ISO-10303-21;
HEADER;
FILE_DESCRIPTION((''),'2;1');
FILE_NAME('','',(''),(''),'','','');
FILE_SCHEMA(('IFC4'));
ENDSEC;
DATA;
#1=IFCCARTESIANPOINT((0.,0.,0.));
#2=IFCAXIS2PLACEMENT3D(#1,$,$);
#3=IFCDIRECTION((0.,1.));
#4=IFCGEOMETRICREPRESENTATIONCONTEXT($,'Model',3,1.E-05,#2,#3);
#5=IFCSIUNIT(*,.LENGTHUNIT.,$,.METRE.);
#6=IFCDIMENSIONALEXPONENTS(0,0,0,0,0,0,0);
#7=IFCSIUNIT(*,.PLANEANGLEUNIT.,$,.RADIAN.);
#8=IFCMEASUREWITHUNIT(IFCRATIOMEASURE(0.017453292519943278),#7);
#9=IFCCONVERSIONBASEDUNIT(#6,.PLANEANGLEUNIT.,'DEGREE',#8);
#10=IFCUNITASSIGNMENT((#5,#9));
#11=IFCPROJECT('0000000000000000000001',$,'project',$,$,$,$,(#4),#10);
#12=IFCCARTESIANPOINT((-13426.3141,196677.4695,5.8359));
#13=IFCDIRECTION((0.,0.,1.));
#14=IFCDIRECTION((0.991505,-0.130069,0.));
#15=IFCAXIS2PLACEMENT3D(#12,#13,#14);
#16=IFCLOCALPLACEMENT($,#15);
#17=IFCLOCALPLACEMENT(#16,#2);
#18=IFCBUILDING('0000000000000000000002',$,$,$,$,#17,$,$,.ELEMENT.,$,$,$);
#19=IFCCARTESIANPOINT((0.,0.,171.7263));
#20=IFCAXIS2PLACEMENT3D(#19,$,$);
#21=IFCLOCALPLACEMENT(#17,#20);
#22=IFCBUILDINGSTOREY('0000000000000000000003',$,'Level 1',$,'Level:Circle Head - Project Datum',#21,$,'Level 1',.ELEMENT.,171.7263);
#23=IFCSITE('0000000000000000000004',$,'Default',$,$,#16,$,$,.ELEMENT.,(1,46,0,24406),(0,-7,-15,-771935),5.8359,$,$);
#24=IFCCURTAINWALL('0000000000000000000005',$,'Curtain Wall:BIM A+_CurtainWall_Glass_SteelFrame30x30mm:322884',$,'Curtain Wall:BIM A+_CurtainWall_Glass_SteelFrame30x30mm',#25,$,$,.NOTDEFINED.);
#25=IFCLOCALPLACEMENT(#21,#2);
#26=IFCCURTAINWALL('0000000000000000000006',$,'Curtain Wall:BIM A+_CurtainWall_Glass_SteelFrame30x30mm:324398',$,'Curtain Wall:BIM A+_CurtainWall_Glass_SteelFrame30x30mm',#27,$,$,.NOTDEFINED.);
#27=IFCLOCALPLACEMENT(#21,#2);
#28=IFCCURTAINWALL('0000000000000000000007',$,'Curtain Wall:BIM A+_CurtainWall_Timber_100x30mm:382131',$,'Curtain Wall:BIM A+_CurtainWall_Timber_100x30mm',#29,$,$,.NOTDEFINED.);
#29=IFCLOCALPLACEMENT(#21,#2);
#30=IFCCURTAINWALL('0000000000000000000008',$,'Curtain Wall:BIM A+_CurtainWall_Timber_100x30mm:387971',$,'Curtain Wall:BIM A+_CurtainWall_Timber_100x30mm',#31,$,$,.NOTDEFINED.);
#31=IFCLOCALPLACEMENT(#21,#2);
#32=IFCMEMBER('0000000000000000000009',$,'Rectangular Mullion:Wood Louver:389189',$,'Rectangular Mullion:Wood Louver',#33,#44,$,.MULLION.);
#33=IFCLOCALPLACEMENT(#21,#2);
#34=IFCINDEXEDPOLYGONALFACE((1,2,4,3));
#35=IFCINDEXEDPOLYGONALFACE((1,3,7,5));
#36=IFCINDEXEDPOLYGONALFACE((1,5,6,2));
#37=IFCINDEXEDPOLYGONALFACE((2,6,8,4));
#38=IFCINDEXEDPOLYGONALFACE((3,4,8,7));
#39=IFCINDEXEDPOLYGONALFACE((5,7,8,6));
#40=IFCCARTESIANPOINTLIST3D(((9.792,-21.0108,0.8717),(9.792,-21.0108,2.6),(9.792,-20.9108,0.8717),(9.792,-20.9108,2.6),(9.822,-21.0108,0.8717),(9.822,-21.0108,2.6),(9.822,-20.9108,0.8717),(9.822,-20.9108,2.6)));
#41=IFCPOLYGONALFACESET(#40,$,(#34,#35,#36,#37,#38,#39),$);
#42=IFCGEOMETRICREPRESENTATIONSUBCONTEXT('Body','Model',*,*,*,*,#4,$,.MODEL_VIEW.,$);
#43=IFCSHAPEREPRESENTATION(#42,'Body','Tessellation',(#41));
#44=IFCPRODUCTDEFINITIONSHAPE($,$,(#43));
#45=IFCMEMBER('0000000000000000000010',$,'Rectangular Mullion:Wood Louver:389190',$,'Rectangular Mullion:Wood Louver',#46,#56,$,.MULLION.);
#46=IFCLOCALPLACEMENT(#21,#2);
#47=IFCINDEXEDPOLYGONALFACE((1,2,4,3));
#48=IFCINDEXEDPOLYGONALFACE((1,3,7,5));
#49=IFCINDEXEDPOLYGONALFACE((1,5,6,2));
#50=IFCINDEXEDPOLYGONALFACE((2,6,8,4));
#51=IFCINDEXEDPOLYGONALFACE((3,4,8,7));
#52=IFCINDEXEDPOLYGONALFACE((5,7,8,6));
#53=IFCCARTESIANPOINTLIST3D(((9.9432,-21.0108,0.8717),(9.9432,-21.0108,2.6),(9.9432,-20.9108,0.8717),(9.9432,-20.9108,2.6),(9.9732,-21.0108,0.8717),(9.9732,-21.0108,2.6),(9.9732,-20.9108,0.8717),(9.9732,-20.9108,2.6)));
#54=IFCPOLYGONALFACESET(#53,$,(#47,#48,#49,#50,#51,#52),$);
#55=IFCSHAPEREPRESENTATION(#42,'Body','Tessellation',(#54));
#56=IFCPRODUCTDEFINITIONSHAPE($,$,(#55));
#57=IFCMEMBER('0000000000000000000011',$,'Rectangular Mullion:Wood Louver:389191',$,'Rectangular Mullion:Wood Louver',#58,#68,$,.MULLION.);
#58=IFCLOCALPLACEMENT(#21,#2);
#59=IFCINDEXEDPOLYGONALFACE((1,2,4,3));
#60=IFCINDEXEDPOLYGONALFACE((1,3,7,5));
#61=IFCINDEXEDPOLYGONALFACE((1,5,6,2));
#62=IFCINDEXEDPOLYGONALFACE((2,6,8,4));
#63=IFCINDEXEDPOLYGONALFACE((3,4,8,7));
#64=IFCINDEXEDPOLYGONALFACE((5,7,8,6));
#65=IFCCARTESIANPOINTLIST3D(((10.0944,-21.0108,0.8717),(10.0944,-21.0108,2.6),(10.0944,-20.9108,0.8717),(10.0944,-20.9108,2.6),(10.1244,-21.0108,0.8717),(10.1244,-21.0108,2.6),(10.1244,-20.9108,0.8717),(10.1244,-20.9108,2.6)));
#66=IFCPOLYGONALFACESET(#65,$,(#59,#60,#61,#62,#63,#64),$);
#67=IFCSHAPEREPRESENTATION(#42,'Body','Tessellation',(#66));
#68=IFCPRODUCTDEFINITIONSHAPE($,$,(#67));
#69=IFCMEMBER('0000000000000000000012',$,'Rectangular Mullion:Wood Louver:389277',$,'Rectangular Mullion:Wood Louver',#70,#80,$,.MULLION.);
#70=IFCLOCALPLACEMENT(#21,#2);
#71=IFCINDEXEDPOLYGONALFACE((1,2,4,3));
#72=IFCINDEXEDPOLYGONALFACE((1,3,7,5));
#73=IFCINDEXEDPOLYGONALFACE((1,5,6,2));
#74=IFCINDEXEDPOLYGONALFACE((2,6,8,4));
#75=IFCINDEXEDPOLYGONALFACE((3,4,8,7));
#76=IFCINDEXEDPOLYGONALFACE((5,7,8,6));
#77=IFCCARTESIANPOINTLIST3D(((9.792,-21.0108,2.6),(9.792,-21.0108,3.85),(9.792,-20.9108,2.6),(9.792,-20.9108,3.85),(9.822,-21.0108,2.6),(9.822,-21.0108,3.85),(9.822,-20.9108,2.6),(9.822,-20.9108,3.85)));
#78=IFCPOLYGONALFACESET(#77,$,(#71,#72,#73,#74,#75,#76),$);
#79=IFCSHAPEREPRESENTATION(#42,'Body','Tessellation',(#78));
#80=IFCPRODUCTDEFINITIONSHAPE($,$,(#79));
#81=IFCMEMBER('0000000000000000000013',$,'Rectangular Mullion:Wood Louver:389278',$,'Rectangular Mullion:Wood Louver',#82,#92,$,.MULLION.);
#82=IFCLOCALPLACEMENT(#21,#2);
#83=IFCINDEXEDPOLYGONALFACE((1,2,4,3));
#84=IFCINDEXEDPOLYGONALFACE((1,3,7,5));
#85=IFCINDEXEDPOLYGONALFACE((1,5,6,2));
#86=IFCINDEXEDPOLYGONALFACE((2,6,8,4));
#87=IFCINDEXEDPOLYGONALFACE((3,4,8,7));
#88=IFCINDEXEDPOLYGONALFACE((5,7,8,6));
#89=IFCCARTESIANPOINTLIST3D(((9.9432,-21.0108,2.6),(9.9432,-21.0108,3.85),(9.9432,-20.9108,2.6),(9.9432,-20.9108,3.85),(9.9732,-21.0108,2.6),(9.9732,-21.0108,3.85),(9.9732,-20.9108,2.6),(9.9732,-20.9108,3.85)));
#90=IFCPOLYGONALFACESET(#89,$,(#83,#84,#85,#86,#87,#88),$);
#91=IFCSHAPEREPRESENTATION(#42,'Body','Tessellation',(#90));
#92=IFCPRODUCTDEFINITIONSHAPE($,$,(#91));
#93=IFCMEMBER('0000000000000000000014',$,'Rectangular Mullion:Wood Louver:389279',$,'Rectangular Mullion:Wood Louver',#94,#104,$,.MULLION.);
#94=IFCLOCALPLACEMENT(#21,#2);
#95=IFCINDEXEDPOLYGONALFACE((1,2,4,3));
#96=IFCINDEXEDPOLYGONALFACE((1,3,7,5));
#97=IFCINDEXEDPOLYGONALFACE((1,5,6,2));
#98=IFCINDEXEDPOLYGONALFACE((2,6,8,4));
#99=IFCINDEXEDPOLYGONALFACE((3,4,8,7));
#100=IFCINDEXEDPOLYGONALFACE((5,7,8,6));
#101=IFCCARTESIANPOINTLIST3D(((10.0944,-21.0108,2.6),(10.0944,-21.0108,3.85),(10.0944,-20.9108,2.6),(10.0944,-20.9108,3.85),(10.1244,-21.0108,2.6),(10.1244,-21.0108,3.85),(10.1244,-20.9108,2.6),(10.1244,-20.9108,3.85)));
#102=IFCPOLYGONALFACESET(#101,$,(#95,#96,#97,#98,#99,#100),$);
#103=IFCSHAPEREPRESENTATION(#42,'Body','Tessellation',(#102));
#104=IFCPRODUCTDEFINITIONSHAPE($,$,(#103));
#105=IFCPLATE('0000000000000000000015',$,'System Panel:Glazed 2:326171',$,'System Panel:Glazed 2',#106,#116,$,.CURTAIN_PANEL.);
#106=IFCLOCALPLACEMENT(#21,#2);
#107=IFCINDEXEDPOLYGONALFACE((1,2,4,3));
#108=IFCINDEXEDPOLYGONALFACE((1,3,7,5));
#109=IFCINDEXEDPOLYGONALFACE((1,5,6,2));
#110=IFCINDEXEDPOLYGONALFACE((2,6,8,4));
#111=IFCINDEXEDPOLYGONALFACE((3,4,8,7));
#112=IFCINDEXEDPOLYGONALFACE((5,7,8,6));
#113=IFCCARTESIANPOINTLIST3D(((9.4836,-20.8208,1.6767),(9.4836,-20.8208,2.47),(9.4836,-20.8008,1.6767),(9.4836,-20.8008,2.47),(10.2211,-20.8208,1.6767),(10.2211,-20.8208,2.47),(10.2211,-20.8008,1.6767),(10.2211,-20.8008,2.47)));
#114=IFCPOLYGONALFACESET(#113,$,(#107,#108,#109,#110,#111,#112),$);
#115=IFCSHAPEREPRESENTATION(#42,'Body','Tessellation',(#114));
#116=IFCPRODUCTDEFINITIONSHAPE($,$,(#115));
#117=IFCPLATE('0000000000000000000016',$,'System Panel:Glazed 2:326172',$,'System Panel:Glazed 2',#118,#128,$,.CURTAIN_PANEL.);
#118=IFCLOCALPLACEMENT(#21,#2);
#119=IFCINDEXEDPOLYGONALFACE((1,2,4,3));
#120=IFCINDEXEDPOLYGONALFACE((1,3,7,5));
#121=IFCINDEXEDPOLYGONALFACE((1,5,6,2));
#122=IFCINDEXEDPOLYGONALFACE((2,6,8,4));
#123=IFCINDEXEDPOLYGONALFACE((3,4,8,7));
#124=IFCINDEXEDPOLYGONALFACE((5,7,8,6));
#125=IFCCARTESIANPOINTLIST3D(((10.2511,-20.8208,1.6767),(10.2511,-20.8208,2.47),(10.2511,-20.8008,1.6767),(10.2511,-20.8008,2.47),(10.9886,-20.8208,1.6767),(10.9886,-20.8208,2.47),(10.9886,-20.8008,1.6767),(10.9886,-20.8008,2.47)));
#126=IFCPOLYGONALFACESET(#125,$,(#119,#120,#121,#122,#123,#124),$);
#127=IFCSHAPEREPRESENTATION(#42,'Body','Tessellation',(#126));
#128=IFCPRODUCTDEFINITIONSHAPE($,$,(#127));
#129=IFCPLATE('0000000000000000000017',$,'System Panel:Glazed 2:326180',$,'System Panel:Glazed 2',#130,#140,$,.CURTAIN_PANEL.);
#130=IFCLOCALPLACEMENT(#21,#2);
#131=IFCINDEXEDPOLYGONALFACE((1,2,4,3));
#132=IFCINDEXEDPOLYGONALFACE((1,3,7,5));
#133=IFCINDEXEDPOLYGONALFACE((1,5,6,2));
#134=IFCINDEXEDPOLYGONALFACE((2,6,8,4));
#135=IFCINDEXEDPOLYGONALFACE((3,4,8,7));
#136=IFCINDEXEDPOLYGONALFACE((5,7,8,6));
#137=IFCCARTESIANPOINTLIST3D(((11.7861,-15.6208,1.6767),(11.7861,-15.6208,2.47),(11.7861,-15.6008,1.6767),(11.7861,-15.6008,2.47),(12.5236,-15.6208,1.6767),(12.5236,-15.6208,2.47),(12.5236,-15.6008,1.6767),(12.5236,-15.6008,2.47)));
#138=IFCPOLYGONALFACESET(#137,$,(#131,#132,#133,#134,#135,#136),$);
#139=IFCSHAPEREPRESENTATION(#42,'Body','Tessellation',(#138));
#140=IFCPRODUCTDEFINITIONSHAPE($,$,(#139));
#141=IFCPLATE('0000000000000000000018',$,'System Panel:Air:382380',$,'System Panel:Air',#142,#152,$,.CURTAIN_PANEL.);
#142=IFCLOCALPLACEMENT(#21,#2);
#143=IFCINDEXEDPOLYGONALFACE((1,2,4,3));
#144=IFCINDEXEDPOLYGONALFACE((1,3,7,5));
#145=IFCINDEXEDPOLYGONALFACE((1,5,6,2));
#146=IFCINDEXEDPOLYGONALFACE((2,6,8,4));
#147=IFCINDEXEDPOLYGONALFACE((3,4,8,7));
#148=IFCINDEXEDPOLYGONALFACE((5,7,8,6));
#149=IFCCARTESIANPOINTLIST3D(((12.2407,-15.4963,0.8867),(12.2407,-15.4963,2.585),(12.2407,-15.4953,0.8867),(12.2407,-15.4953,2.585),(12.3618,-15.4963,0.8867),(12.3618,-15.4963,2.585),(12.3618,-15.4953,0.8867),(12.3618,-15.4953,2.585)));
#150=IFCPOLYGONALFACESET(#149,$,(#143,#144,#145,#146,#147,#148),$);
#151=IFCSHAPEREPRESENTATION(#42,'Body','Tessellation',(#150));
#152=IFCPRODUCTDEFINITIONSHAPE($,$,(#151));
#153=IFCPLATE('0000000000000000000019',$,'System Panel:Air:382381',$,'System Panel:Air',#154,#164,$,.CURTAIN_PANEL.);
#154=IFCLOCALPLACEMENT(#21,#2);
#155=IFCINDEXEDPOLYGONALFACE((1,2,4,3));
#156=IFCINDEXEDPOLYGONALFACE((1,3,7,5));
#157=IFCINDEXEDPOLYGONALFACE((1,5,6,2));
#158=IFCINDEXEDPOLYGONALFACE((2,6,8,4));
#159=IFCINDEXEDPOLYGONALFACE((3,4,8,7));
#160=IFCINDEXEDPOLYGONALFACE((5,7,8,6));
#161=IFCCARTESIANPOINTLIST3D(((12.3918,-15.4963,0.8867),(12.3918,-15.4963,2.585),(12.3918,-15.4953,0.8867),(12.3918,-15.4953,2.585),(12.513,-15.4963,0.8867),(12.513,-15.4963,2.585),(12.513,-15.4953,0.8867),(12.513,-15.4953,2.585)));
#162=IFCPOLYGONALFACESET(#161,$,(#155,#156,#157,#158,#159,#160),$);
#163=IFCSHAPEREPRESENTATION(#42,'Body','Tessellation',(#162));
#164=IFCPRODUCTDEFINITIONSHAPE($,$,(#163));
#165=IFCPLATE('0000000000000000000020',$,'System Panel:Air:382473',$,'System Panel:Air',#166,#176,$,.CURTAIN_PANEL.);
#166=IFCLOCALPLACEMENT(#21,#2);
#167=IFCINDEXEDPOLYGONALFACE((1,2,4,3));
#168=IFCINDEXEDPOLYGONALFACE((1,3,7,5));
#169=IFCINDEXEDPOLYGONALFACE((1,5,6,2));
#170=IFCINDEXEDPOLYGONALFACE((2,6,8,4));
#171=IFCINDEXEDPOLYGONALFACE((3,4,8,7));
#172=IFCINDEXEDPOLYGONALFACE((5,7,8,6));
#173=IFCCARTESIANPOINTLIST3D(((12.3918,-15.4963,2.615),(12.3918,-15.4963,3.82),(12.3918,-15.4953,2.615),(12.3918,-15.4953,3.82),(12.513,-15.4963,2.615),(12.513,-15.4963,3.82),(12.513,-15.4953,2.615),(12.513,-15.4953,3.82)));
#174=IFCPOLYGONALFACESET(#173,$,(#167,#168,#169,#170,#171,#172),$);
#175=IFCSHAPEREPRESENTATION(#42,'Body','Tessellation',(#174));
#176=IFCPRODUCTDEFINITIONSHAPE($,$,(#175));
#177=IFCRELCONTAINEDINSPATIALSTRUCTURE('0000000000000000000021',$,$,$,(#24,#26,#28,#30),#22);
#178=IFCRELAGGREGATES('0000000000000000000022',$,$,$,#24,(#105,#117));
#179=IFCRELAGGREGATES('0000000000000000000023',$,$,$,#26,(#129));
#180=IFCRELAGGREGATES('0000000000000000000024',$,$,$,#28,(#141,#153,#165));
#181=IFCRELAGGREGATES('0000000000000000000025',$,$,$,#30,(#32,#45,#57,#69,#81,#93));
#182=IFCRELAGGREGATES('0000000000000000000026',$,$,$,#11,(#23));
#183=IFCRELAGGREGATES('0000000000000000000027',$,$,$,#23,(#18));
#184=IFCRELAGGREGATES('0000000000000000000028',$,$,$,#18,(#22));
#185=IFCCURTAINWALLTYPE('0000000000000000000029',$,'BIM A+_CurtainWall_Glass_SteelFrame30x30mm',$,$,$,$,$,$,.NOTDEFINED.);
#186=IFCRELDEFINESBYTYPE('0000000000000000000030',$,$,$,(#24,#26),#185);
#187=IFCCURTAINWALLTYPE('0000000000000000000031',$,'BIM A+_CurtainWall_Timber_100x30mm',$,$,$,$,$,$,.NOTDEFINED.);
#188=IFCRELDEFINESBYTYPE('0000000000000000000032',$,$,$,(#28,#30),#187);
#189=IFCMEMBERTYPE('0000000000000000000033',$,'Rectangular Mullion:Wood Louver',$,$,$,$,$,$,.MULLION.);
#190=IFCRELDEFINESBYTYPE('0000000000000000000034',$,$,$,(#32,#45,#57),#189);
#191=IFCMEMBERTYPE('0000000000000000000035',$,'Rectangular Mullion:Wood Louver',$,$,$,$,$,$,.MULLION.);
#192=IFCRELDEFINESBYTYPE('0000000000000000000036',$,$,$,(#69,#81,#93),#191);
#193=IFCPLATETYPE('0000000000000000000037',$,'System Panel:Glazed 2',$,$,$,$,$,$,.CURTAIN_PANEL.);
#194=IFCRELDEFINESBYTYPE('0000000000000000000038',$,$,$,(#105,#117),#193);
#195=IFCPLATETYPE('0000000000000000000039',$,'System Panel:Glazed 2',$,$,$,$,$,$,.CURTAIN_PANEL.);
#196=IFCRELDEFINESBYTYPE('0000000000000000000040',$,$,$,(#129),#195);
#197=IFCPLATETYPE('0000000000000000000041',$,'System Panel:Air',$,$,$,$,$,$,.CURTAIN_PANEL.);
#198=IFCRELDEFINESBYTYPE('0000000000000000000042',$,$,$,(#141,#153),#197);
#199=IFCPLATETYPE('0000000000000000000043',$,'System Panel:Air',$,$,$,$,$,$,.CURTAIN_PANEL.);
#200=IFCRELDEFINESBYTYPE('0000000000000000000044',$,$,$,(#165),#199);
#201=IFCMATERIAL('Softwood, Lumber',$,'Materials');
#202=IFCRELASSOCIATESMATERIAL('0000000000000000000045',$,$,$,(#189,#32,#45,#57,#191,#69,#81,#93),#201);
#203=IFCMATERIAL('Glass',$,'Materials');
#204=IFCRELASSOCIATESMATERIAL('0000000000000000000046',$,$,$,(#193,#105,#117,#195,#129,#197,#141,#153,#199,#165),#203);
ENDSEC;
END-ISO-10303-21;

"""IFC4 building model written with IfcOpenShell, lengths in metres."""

from ifc_helpers import new_model, entity, si_unit, converted_unit, direction, frame, origin, place, context, subcontext, project, spatial, indexed_curve, outline, extrude, source, transform, mapped, material, type_object, type_shapes, element, aggregate, save


model = new_model("IFC4")

# Units and contexts
model_context = context("Model", 3, precision=1e-05, world=origin(), true_north=direction((0.0, 1.0)))
body_context = subcontext(model_context, "Body", "Model", "MODEL_VIEW")
ifc_project = project(units=[si_unit("LENGTHUNIT", "METRE"), converted_unit("PLANEANGLEUNIT", "DEGREE", entity("IfcRatioMeasure", 0.017453292519943278), si_unit("PLANEANGLEUNIT", "RADIAN"), dimensions=[0, 0, 0, 0, 0, 0, 0])], contexts=[model_context])

# Site, building, storey
site_placement = place(None, frame((-13426.3141, 196677.4695, 5.8359), z_axis=(0.0, 0.0, 1.0), x_axis=(0.991505, -0.130069, 0.0)))
site = spatial("IfcSite", under=ifc_project, at=site_placement, Name="Default", CompositionType="ELEMENT", RefLatitude=(1, 46, 0, 24406), RefLongitude=(0, -7, -15, -771935), RefElevation=5.8359)
building_placement = place(site_placement, origin())
building = spatial("IfcBuilding", under=site, at=building_placement, CompositionType="ELEMENT")
storey_placement = place(building_placement, frame((0.0, 0.0, 171.7263)))
storey = spatial("IfcBuildingStorey", under=building, at=storey_placement, Name="Level 1", ObjectType="Level:Circle Head - Project Datum", LongName="Level 1", CompositionType="ELEMENT", Elevation=171.7263)

# Curtain walls, members
curtain_wall_type_1 = type_object("IfcCurtainWallType", Name="BIM A+_CurtainWall_Glass_SteelFrame30x30mm", PredefinedType="NOTDEFINED")
curtain_wall_1_placement = place(storey_placement, frame((0.0, 0.0, -171.7263)))
curtain_wall_1 = element("IfcCurtainWall", 1, at=curtain_wall_1_placement, inside=storey, type_object=curtain_wall_type_1, Name="Curtain Wall:BIM A+_CurtainWall_Glass_SteelFrame30x30mm:322884", ObjectType="Curtain Wall:BIM A+_CurtainWall_Glass_SteelFrame30x30mm", PredefinedType="NOTDEFINED")
curtain_wall_2_placement = place(storey_placement, frame((0.0, 0.0, -171.7263)))
curtain_wall_2 = element("IfcCurtainWall", 2, at=curtain_wall_2_placement, inside=storey, type_object=curtain_wall_type_1, Name="Curtain Wall:BIM A+_CurtainWall_Glass_SteelFrame30x30mm:324398", ObjectType="Curtain Wall:BIM A+_CurtainWall_Glass_SteelFrame30x30mm", PredefinedType="NOTDEFINED")
curtain_wall_type_2 = type_object("IfcCurtainWallType", Name="BIM A+_CurtainWall_Timber_100x30mm", PredefinedType="NOTDEFINED")
curtain_wall_3_placement = place(storey_placement, frame((0.0, 0.0, -171.7263)))
curtain_wall_3 = element("IfcCurtainWall", 3, at=curtain_wall_3_placement, inside=storey, type_object=curtain_wall_type_2, Name="Curtain Wall:BIM A+_CurtainWall_Timber_100x30mm:382131", ObjectType="Curtain Wall:BIM A+_CurtainWall_Timber_100x30mm", PredefinedType="NOTDEFINED")
ifc_material_1 = material(Name="Softwood, Lumber", Category="Materials")
curtain_wall_4_placement = place(storey_placement, frame((0.0, 0.0, -171.7263)))
curtain_wall_4 = element("IfcCurtainWall", 4, at=curtain_wall_4_placement, inside=storey, type_object=curtain_wall_type_2, Name="Curtain Wall:BIM A+_CurtainWall_Timber_100x30mm:387971", ObjectType="Curtain Wall:BIM A+_CurtainWall_Timber_100x30mm", PredefinedType="NOTDEFINED")
member_type_1 = type_object("IfcMemberType", Name="Rectangular Mullion:Wood Louver", PredefinedType="MULLION", material=ifc_material_1)
shared_shape_1 = source(origin(), body_context, "Body", "SweptSolid", [
    extrude(outline(indexed_curve([(-0.05, -0.015), (0.05, -0.015), (0.05, 0.015), (-0.05, 0.015), (-0.05, -0.015)], self_intersect=False)), frame((0.0, 0.035, -1.7283), z_axis=(0.0, 0.0, 1.0), x_axis=(0.0, -1.0, 0.0)), (0.0, 0.0, 1.0), 1.7283),
])
type_shapes(member_type_1, [shared_shape_1])
member_1_placement = place(curtain_wall_4_placement, frame((9.807, -20.9258, 172.598), z_axis=(0.0, 0.0, -1.0), x_axis=(1.0, 0.0, 0.0)))
member_1 = element("IfcMember", 5, at=member_1_placement, type_object=member_type_1, material=ifc_material_1, Name="Rectangular Mullion:Wood Louver:389189", ObjectType="Rectangular Mullion:Wood Louver", PredefinedType="MULLION", context=body_context, shape_type="MappedRepresentation", body=[
    mapped(shared_shape_1, transform((0.0, 0.0, 0.0), scale=1.0)),
])
member_2_placement = place(curtain_wall_4_placement, frame((9.9582, -20.9258, 172.598), z_axis=(0.0, 0.0, -1.0), x_axis=(1.0, 0.0, 0.0)))
member_2 = element("IfcMember", 6, at=member_2_placement, type_object=member_type_1, material=ifc_material_1, Name="Rectangular Mullion:Wood Louver:389190", ObjectType="Rectangular Mullion:Wood Louver", PredefinedType="MULLION", context=body_context, shape_type="MappedRepresentation", body=[
    mapped(shared_shape_1, transform((0.0, 0.0, 0.0), scale=1.0)),
])
member_3_placement = place(curtain_wall_4_placement, frame((10.1094, -20.9258, 172.598), z_axis=(0.0, 0.0, -1.0), x_axis=(1.0, 0.0, 0.0)))
member_3 = element("IfcMember", 7, at=member_3_placement, type_object=member_type_1, material=ifc_material_1, Name="Rectangular Mullion:Wood Louver:389191", ObjectType="Rectangular Mullion:Wood Louver", PredefinedType="MULLION", context=body_context, shape_type="MappedRepresentation", body=[
    mapped(shared_shape_1, transform((0.0, 0.0, 0.0), scale=1.0)),
])
member_type_2 = type_object("IfcMemberType", Name="Rectangular Mullion:Wood Louver", PredefinedType="MULLION", material=ifc_material_1)
shared_shape_2 = source(origin(), body_context, "Body", "SweptSolid", [
    extrude(outline(indexed_curve([(-0.05, -0.015), (0.05, -0.015), (0.05, 0.015), (-0.05, 0.015), (-0.05, -0.015)], self_intersect=False)), frame((0.0, 0.035, -1.25), z_axis=(0.0, 0.0, 1.0), x_axis=(0.0, -1.0, 0.0)), (0.0, 0.0, 1.0), 1.25),
])
type_shapes(member_type_2, [shared_shape_2])
member_4_placement = place(curtain_wall_4_placement, frame((9.807, -20.9258, 174.3263), z_axis=(0.0, 0.0, -1.0), x_axis=(1.0, 0.0, 0.0)))
member_4 = element("IfcMember", 8, at=member_4_placement, type_object=member_type_2, material=ifc_material_1, Name="Rectangular Mullion:Wood Louver:389277", ObjectType="Rectangular Mullion:Wood Louver", PredefinedType="MULLION", context=body_context, shape_type="MappedRepresentation", body=[
    mapped(shared_shape_2, transform((0.0, 0.0, 0.0), scale=1.0)),
])
member_5_placement = place(curtain_wall_4_placement, frame((9.9582, -20.9258, 174.3263), z_axis=(0.0, 0.0, -1.0), x_axis=(1.0, 0.0, 0.0)))
member_5 = element("IfcMember", 9, at=member_5_placement, type_object=member_type_2, material=ifc_material_1, Name="Rectangular Mullion:Wood Louver:389278", ObjectType="Rectangular Mullion:Wood Louver", PredefinedType="MULLION", context=body_context, shape_type="MappedRepresentation", body=[
    mapped(shared_shape_2, transform((0.0, 0.0, 0.0), scale=1.0)),
])
member_6_placement = place(curtain_wall_4_placement, frame((10.1094, -20.9258, 174.3263), z_axis=(0.0, 0.0, -1.0), x_axis=(1.0, 0.0, 0.0)))
member_6 = element("IfcMember", 10, at=member_6_placement, type_object=member_type_2, material=ifc_material_1, Name="Rectangular Mullion:Wood Louver:389279", ObjectType="Rectangular Mullion:Wood Louver", PredefinedType="MULLION", context=body_context, shape_type="MappedRepresentation", body=[
    mapped(shared_shape_2, transform((0.0, 0.0, 0.0), scale=1.0)),
])

# Plates
ifc_material_2 = material(Name="Glass", Category="Materials")
plate_type_1 = type_object("IfcPlateType", Name="System Panel:Glazed 2", PredefinedType="CURTAIN_PANEL", material=ifc_material_2)
shared_shape_3 = source(origin(), body_context, "Body", "SweptSolid", [
    extrude(outline(indexed_curve([(-0.01, -0.3688), (0.01, -0.3688), (0.01, 0.3688), (-0.01, 0.3688), (-0.01, -0.3688)], self_intersect=False)), frame((0.0, 0.0, 0.0), z_axis=(0.0, 0.0, 1.0), x_axis=(0.0, 1.0, 0.0)), (0.0, 0.0, 1.0), 0.7933),
])
type_shapes(plate_type_1, [shared_shape_3])
plate_1_placement = place(curtain_wall_1_placement, frame((9.8523, -20.8108, 173.4029)))
plate_1 = element("IfcPlate", 11, at=plate_1_placement, type_object=plate_type_1, material=ifc_material_2, Name="System Panel:Glazed 2:326171", ObjectType="System Panel:Glazed 2", PredefinedType="CURTAIN_PANEL", context=body_context, shape_type="MappedRepresentation", body=[
    mapped(shared_shape_3, transform((0.0, 0.0, 0.0), scale=1.0)),
])
plate_2_placement = place(curtain_wall_1_placement, frame((10.6198, -20.8108, 173.4029)))
plate_2 = element("IfcPlate", 12, at=plate_2_placement, type_object=plate_type_1, material=ifc_material_2, Name="System Panel:Glazed 2:326172", ObjectType="System Panel:Glazed 2", PredefinedType="CURTAIN_PANEL", context=body_context, shape_type="MappedRepresentation", body=[
    mapped(shared_shape_3, transform((0.0, 0.0, 0.0), scale=1.0)),
])
aggregate(curtain_wall_1, [plate_1, plate_2])
plate_type_2 = type_object("IfcPlateType", Name="System Panel:Glazed 2", PredefinedType="CURTAIN_PANEL", material=ifc_material_2)
shared_shape_4 = source(origin(), body_context, "Body", "SweptSolid", [
    extrude(outline(indexed_curve([(-0.01, -0.3688), (0.01, -0.3688), (0.01, 0.3688), (-0.01, 0.3688), (-0.01, -0.3688)], self_intersect=False)), frame((0.0, 0.0, 0.0), z_axis=(0.0, 0.0, 1.0), x_axis=(0.0, 1.0, 0.0)), (0.0, 0.0, 1.0), 0.7933),
])
type_shapes(plate_type_2, [shared_shape_4])
plate_3_placement = place(curtain_wall_2_placement, frame((12.1548, -15.6108, 173.4029), z_axis=(0.0, 0.0, 1.0), x_axis=(-1.0, 0.0, 0.0)))
plate_3 = element("IfcPlate", 13, at=plate_3_placement, type_object=plate_type_2, material=ifc_material_2, Name="System Panel:Glazed 2:326180", ObjectType="System Panel:Glazed 2", PredefinedType="CURTAIN_PANEL", context=body_context, shape_type="MappedRepresentation", body=[
    mapped(shared_shape_4, transform((0.0, 0.0, 0.0), scale=1.0)),
])
aggregate(curtain_wall_2, [plate_3])
plate_type_3 = type_object("IfcPlateType", Name="System Panel:Air", PredefinedType="CURTAIN_PANEL", material=ifc_material_2)
shared_shape_5 = source(origin(), body_context, "Body", "SweptSolid", [
    extrude(outline(indexed_curve([(-0.0005, -0.0606), (0.0005, -0.0606), (0.0005, 0.0606), (-0.0005, 0.0606), (-0.0005, -0.0606)], self_intersect=False)), frame((0.0, 0.0, 0.0), z_axis=(0.0, 0.0, 1.0), x_axis=(0.0, 1.0, 0.0)), (0.0, 0.0, 1.0), 1.6983),
])
type_shapes(plate_type_3, [shared_shape_5])
plate_4_placement = place(curtain_wall_3_placement, frame((12.3012, -15.4958, 172.613)))
plate_4 = element("IfcPlate", 14, at=plate_4_placement, type_object=plate_type_3, material=ifc_material_2, Name="System Panel:Air:382380", ObjectType="System Panel:Air", PredefinedType="CURTAIN_PANEL", context=body_context, shape_type="MappedRepresentation", body=[
    mapped(shared_shape_5, transform((0.0, 0.0, 0.0), scale=1.0)),
])
plate_5_placement = place(curtain_wall_3_placement, frame((12.4524, -15.4958, 172.613)))
plate_5 = element("IfcPlate", 15, at=plate_5_placement, type_object=plate_type_3, material=ifc_material_2, Name="System Panel:Air:382381", ObjectType="System Panel:Air", PredefinedType="CURTAIN_PANEL", context=body_context, shape_type="MappedRepresentation", body=[
    mapped(shared_shape_5, transform((0.0, 0.0, 0.0), scale=1.0)),
])
plate_type_4 = type_object("IfcPlateType", Name="System Panel:Air", PredefinedType="CURTAIN_PANEL", material=ifc_material_2)
shared_shape_6 = source(origin(), body_context, "Body", "SweptSolid", [
    extrude(outline(indexed_curve([(-0.0005, -0.0606), (0.0005, -0.0606), (0.0005, 0.0606), (-0.0005, 0.0606), (-0.0005, -0.0606)], self_intersect=False)), frame((0.0, 0.0, 0.0), z_axis=(0.0, 0.0, 1.0), x_axis=(0.0, 1.0, 0.0)), (0.0, 0.0, 1.0), 1.205),
])
type_shapes(plate_type_4, [shared_shape_6])
plate_6_placement = place(curtain_wall_3_placement, frame((12.4524, -15.4958, 174.3413)))
plate_6 = element("IfcPlate", 16, at=plate_6_placement, type_object=plate_type_4, material=ifc_material_2, Name="System Panel:Air:382473", ObjectType="System Panel:Air", PredefinedType="CURTAIN_PANEL", context=body_context, shape_type="MappedRepresentation", body=[
    mapped(shared_shape_6, transform((0.0, 0.0, 0.0), scale=1.0)),
])
aggregate(curtain_wall_3, [plate_4, plate_5, plate_6])
aggregate(curtain_wall_4, [member_1, member_2, member_3, member_4, member_5, member_6])

save(model, "model.ifc")
